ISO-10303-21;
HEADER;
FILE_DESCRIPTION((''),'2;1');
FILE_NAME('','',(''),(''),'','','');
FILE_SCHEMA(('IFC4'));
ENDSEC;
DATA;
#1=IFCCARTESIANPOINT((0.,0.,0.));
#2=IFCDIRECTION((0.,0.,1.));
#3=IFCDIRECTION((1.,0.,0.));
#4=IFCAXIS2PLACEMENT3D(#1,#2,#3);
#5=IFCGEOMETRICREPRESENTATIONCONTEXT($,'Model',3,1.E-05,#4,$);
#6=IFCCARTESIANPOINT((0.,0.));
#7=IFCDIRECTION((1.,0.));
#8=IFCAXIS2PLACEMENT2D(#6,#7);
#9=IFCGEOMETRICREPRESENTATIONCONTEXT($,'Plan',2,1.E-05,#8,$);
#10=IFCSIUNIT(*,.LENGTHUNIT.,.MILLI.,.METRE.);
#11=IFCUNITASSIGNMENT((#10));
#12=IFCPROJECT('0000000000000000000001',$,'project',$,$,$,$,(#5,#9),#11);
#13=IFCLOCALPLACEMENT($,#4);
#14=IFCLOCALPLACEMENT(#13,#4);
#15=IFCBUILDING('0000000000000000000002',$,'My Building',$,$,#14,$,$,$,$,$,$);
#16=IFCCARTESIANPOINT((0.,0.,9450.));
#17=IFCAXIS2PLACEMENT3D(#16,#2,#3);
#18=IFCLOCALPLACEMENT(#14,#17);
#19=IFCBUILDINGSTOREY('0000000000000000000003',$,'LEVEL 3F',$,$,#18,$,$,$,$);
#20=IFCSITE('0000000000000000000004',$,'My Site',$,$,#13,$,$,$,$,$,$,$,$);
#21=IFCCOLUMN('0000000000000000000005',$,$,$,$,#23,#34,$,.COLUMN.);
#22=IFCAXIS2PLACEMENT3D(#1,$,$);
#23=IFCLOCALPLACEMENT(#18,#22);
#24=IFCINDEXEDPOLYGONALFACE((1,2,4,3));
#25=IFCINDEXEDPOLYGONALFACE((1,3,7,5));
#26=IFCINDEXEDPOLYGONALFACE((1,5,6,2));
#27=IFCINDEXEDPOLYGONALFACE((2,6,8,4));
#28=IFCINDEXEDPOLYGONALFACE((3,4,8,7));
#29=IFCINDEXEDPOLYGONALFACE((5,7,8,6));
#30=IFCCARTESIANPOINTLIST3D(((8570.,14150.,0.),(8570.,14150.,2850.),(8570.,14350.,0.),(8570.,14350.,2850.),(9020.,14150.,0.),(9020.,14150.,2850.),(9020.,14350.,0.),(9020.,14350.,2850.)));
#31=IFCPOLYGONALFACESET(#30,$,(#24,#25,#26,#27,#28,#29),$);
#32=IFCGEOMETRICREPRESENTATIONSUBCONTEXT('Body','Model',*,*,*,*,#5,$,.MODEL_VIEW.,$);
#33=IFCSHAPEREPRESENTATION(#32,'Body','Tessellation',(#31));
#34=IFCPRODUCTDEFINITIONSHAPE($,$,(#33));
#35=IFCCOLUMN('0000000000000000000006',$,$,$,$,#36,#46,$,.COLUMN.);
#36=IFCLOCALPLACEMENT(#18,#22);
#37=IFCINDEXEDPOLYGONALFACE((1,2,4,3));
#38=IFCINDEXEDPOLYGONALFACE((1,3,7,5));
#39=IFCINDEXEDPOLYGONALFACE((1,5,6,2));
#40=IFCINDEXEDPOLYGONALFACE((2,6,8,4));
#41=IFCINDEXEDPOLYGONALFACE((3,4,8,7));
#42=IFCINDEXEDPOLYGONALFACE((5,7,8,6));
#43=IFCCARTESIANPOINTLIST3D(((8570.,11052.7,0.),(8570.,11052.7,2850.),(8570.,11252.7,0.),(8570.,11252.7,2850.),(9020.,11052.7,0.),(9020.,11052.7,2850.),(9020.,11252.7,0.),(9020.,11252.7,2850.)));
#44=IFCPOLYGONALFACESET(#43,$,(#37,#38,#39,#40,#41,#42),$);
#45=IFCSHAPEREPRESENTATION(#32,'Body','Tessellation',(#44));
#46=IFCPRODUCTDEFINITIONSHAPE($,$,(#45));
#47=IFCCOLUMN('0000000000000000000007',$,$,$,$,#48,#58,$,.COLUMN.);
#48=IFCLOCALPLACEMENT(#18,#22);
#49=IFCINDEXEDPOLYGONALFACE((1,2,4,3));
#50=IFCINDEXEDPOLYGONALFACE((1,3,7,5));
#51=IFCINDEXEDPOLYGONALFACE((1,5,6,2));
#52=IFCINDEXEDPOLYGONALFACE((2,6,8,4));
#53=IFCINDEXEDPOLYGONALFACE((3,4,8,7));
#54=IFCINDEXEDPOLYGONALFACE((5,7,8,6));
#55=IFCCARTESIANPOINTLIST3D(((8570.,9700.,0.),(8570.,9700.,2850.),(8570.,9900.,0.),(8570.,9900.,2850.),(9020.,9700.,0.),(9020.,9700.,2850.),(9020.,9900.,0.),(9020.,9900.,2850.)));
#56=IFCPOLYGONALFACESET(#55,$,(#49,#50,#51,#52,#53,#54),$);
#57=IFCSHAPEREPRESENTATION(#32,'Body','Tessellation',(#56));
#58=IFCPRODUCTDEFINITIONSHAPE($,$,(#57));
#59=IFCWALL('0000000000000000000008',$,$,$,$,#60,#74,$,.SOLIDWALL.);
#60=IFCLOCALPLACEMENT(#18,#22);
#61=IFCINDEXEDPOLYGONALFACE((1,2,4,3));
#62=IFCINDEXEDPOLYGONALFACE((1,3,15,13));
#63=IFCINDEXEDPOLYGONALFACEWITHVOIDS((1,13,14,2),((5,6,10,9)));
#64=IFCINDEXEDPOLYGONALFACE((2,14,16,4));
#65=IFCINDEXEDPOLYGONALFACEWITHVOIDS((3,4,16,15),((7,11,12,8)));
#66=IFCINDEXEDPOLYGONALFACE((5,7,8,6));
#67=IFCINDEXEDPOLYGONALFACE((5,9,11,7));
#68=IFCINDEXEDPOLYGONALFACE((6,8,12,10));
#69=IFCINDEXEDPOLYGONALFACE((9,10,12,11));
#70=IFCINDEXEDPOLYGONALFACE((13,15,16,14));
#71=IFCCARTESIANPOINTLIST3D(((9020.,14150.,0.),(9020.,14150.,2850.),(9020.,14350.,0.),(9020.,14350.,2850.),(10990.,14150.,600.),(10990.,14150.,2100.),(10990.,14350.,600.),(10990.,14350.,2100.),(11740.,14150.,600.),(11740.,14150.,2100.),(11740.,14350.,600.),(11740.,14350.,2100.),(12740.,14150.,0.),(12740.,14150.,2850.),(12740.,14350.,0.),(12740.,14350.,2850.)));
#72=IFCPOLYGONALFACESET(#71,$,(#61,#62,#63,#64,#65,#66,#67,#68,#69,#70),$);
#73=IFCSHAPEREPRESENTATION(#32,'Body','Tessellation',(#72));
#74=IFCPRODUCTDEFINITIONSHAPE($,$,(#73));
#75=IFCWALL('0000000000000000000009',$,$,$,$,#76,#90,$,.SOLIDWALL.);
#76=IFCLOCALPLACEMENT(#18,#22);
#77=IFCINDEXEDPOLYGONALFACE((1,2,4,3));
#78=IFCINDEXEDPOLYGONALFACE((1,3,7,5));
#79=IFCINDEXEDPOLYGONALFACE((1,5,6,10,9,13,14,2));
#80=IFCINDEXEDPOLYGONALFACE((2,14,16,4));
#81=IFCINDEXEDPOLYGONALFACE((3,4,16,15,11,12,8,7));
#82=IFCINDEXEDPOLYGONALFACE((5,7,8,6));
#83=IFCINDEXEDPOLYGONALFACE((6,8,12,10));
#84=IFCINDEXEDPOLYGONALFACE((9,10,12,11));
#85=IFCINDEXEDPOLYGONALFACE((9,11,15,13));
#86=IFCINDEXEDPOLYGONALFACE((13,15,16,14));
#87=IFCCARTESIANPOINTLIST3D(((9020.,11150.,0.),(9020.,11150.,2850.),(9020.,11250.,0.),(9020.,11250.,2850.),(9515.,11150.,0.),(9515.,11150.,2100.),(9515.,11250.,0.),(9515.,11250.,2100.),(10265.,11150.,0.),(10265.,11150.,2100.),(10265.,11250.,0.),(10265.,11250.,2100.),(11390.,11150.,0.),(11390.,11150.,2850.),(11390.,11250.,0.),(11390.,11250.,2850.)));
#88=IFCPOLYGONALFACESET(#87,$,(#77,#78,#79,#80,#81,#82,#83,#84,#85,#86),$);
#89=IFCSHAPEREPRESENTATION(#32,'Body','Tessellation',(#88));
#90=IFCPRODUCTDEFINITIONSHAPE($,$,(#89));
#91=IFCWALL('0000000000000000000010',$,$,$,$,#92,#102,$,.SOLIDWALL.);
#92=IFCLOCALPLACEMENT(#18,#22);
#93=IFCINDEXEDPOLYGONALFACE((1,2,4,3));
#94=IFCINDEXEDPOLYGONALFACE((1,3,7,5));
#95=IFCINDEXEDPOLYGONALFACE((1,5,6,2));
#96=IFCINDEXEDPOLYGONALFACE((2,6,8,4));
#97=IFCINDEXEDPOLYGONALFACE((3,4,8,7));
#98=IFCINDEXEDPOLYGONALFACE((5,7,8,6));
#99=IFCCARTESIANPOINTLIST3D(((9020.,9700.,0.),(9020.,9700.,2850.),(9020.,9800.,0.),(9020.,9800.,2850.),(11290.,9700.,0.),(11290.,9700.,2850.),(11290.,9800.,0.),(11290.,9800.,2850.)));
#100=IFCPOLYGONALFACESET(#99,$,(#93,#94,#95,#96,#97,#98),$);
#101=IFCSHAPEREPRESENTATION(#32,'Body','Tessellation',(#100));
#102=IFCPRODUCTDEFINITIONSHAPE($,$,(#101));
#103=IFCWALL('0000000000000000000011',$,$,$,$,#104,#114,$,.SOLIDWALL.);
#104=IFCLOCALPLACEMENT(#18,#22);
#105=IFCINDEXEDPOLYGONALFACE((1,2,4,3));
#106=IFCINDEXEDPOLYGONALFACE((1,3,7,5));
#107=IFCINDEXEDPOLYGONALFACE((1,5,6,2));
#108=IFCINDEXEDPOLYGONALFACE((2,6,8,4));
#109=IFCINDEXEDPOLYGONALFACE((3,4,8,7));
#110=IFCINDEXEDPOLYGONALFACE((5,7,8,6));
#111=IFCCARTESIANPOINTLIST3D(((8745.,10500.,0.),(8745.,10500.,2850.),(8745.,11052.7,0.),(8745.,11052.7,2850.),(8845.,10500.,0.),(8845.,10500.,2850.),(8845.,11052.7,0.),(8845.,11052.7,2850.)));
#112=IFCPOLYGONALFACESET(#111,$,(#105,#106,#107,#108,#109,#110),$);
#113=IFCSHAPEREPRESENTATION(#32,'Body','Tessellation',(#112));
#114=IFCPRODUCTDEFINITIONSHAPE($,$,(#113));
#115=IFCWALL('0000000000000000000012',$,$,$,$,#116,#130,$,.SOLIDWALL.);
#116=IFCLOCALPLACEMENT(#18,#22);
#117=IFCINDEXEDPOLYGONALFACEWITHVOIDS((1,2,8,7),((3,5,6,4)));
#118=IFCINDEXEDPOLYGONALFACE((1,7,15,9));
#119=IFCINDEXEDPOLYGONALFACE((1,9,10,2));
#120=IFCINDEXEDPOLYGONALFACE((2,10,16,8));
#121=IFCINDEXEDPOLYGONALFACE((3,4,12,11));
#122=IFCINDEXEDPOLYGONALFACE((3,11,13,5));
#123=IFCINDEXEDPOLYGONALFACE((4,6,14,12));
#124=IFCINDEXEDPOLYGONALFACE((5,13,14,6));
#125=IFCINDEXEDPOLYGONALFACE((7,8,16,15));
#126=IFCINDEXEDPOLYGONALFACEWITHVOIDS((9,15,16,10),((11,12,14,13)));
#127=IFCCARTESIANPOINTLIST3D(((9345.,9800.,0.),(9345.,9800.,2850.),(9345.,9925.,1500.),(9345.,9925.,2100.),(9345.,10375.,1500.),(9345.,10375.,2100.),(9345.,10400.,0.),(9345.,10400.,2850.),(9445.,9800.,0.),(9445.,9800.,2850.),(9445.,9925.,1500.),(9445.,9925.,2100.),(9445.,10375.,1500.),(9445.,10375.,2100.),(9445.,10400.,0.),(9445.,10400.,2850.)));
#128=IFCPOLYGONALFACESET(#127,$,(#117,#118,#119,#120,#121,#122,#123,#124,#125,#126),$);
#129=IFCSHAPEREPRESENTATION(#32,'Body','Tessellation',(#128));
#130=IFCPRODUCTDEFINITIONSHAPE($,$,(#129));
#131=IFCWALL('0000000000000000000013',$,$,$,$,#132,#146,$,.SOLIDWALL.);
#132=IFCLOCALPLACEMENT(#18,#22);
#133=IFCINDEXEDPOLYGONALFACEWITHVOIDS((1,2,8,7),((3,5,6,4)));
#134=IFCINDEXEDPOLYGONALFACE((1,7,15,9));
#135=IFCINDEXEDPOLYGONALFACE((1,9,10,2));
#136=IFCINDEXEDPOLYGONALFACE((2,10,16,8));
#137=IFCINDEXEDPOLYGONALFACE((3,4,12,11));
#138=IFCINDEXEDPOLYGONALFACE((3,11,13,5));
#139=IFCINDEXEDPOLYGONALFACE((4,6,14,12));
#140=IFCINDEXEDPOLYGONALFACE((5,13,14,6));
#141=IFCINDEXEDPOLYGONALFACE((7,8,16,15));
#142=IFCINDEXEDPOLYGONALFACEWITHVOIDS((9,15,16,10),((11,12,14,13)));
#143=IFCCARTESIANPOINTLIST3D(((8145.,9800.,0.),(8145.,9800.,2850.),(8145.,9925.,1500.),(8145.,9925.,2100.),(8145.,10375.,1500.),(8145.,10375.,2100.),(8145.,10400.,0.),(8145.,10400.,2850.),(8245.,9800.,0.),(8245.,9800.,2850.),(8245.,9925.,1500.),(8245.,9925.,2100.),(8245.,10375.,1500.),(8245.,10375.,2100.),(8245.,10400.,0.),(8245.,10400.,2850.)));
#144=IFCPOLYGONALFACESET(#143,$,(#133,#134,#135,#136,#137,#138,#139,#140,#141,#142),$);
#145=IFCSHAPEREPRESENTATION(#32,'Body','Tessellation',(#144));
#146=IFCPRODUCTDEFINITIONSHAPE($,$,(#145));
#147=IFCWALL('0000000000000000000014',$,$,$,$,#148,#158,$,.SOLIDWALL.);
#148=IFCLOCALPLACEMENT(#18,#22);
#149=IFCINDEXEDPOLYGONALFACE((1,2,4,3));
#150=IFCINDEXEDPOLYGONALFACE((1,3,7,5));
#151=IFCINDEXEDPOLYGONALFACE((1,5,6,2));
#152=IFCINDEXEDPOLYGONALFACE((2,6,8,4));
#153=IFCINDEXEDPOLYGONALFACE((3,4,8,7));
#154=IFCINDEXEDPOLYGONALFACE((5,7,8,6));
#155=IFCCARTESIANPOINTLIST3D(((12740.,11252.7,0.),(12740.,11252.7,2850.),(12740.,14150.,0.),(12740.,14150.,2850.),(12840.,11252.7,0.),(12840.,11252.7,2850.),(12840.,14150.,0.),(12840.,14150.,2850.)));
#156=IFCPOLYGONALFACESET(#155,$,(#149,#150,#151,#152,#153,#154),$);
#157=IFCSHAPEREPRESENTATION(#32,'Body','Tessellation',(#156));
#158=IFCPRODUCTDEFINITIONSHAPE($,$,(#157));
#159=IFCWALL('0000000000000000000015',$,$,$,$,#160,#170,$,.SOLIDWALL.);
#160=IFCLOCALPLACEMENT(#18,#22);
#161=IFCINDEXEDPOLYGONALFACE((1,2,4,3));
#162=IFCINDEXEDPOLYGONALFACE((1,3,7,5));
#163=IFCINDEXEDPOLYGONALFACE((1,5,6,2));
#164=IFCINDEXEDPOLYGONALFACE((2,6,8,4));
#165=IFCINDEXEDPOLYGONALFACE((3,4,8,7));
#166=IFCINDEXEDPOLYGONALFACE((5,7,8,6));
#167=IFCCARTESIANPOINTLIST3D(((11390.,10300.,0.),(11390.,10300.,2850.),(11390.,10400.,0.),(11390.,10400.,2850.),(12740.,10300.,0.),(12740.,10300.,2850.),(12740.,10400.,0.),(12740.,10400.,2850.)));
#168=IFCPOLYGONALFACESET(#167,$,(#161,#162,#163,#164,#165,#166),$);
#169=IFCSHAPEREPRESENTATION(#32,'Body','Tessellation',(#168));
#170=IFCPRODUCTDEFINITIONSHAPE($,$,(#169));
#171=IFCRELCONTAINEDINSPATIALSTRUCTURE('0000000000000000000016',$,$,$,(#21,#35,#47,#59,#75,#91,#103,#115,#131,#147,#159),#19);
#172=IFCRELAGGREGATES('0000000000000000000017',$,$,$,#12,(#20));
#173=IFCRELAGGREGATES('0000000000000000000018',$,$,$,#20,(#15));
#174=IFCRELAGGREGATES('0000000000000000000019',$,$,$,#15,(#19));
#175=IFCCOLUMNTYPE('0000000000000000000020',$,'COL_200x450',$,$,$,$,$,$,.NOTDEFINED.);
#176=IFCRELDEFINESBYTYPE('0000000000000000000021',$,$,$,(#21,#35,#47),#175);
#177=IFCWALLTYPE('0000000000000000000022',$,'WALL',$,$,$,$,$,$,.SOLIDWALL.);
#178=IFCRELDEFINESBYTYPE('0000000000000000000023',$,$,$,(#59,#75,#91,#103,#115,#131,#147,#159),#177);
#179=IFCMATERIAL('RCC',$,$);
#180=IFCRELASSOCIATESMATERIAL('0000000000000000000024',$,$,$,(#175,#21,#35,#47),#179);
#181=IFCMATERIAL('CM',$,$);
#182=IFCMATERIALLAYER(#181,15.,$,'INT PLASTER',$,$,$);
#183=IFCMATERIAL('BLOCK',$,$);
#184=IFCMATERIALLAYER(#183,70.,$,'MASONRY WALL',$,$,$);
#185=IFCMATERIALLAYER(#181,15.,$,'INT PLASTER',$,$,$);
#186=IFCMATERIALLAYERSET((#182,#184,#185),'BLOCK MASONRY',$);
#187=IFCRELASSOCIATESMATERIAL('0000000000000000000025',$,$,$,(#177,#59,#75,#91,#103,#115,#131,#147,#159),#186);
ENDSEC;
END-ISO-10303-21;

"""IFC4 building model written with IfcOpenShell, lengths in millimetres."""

from ifc_helpers import new_model, si_unit, frame, origin_with_axes, origin_2d_with_axis, place, context, subcontext, project, spatial, indexed_curve, rectangle, outline, extrude, material, layer, layer_set, layer_usage, material_profile, profile_set, profile_usage, type_object, element, save


model = new_model("IFC4")

# Units and contexts
model_context = context("Model", 3, precision=1e-05, world=origin_with_axes())
plan_context = context("Plan", 2, precision=1e-05, world=origin_2d_with_axis())
body_context = subcontext(model_context, "Body", "Model", "MODEL_VIEW")
ifc_project = project(units=[si_unit("LENGTHUNIT", "METRE", prefix="MILLI")], contexts=[model_context, plan_context])

# Site, building, storey
site_placement = place(None, origin_with_axes())
site = spatial("IfcSite", under=ifc_project, at=site_placement, Name="My Site")
building_placement = place(site_placement, origin_with_axes())
building = spatial("IfcBuilding", under=site, at=building_placement, Name="My Building")
storey_placement = place(building_placement, frame((0.0, 0.0, 9450.0), z_axis=(0.0, 0.0, 1.0), x_axis=(1.0, 0.0, 0.0)))
storey = spatial("IfcBuildingStorey", under=building, at=storey_placement, Name="LEVEL 3F")

# Columns
ifc_material_1 = material(Name="RCC")
ifc_material_profile = material_profile(ifc_material_1, rectangle(XDim=200.0, YDim=450.0))
ifc_profile_set = profile_set([ifc_material_profile], Name="COL_200x450")
ifc_profile_usage_1 = profile_usage(ifc_profile_set)
column_type = type_object("IfcColumnType", Name="COL_200x450", PredefinedType="NOTDEFINED", material=ifc_profile_set)
column_1_placement = place(storey_placement, frame((8795.0, 14250.0, 0.0), z_axis=(0.0, 0.0, 1.0), x_axis=(0.0, -1.0, 0.0)))
element("IfcColumn", 1, at=column_1_placement, inside=storey, type_object=column_type, material=ifc_profile_usage_1, PredefinedType="COLUMN", context=body_context, shape_type="SweptSolid", body=[
    extrude(rectangle(XDim=200.0, YDim=450.0), origin_with_axes(), (0.0, 0.0, 1.0), 2850.0),
])
ifc_profile_usage_2 = profile_usage(ifc_profile_set)
column_2_placement = place(storey_placement, frame((8795.0, 11152.7, 0.0), z_axis=(0.0, 0.0, 1.0), x_axis=(0.0, -1.0, 0.0)))
element("IfcColumn", 2, at=column_2_placement, inside=storey, type_object=column_type, material=ifc_profile_usage_2, PredefinedType="COLUMN", context=body_context, shape_type="SweptSolid", body=[
    extrude(rectangle(XDim=200.0, YDim=450.0), origin_with_axes(), (0.0, 0.0, 1.0), 2850.0),
])
ifc_profile_usage_3 = profile_usage(ifc_profile_set)
column_3_placement = place(storey_placement, frame((8795.0, 9800.0, 0.0), z_axis=(0.0, 0.0, 1.0), x_axis=(0.0, -1.0, 0.0)))
element("IfcColumn", 3, at=column_3_placement, inside=storey, type_object=column_type, material=ifc_profile_usage_3, PredefinedType="COLUMN", context=body_context, shape_type="SweptSolid", body=[
    extrude(rectangle(XDim=200.0, YDim=450.0), origin_with_axes(), (0.0, 0.0, 1.0), 2850.0),
])

# Walls, openings
ifc_material_2 = material(Name="CM")
ifc_layer_1 = layer(ifc_material_2, 15.0, Name="INT PLASTER")
ifc_material_3 = material(Name="BLOCK")
ifc_layer_2 = layer(ifc_material_3, 70.0, Name="MASONRY WALL")
ifc_layer_3 = layer(ifc_material_2, 15.0, Name="INT PLASTER")
ifc_layer_set = layer_set([ifc_layer_1, ifc_layer_2, ifc_layer_3], Name="BLOCK MASONRY")
ifc_layer_usage_1 = layer_usage(ifc_layer_set, "AXIS2", "POSITIVE", 0.0)
wall_type = type_object("IfcWallType", Name="WALL", PredefinedType="SOLIDWALL", material=ifc_layer_set)
wall_1_placement = place(storey_placement, frame((9020.0, 14350.0, 0.0), z_axis=(0.0, 0.0, 1.0), x_axis=(0.0, -1.0, 0.0)))
wall_1 = element("IfcWall", 4, at=wall_1_placement, inside=storey, type_object=wall_type, material=ifc_layer_usage_1, PredefinedType="SOLIDWALL", context=body_context, shape_type="SweptSolid", body=[
    extrude(outline(indexed_curve([(0.0, 0.0), (0.0, 3720.0), (200.0, 3720.0), (200.0, 0.0), (0.0, 0.0)], self_intersect=False)), origin_with_axes(), (0.0, 0.0, 1.0), 2850.0),
])
opening_1_placement = place(wall_1_placement, frame((200.0, 1970.0, 600.0), z_axis=(0.0, 0.0, 1.0), x_axis=(0.0, 1.0, 0.0)))
element("IfcOpeningElement", 5, at=opening_1_placement, cuts=wall_1, PredefinedType="OPENING", context=body_context, shape_type="SweptSolid", body=[
    extrude(outline(indexed_curve([(0.0, 0.0), (0.0, 400.0), (750.0, 400.0), (750.0, 0.0), (0.0, 0.0)], self_intersect=False)), frame((0.0, -100.0, 0.0), z_axis=(0.0, 0.0, 1.0), x_axis=(1.0, 0.0, 0.0)), (0.0, 0.0, 1.0), 1500.0),
])
ifc_layer_usage_2 = layer_usage(ifc_layer_set, "AXIS2", "POSITIVE", 0.0)
wall_2_placement = place(storey_placement, frame((9020.0, 11250.0, 0.0), z_axis=(0.0, 0.0, 1.0), x_axis=(0.0, -1.0, 0.0)))
wall_2 = element("IfcWall", 6, at=wall_2_placement, inside=storey, type_object=wall_type, material=ifc_layer_usage_2, PredefinedType="SOLIDWALL", context=body_context, shape_type="SweptSolid", body=[
    extrude(outline(indexed_curve([(0.0, 0.0), (0.0, 2370.0), (100.0, 2370.0), (100.0, 0.0), (0.0, 0.0)], self_intersect=False)), origin_with_axes(), (0.0, 0.0, 1.0), 2850.0),
])
opening_2_placement = place(wall_2_placement, frame((0.0, 1245.0, 0.0), z_axis=(0.0, 0.0, 1.0), x_axis=(0.0, -1.0, 0.0)))
element("IfcOpeningElement", 7, at=opening_2_placement, cuts=wall_2, PredefinedType="OPENING", context=body_context, shape_type="SweptSolid", body=[
    extrude(outline(indexed_curve([(0.0, 0.0), (0.0, 400.0), (750.0, 400.0), (750.0, 0.0), (0.0, 0.0)], self_intersect=False)), frame((0.0, -100.0, 0.0), z_axis=(0.0, 0.0, 1.0), x_axis=(1.0, 0.0, 0.0)), (0.0, 0.0, 1.0), 2100.0),
])

# Wall
ifc_layer_usage_3 = layer_usage(ifc_layer_set, "AXIS2", "POSITIVE", 0.0)
wall_3_placement = place(storey_placement, frame((9020.0, 9800.0, 0.0), z_axis=(0.0, 0.0, 1.0), x_axis=(0.0, -1.0, 0.0)))
element("IfcWall", 8, at=wall_3_placement, inside=storey, type_object=wall_type, material=ifc_layer_usage_3, PredefinedType="SOLIDWALL", context=body_context, shape_type="SweptSolid", body=[
    extrude(outline(indexed_curve([(0.0, 0.0), (0.0, 2270.0), (100.0, 2270.0), (100.0, 0.0), (0.0, 0.0)], self_intersect=False)), origin_with_axes(), (0.0, 0.0, 1.0), 2850.0),
])

# Wall
ifc_layer_usage_4 = layer_usage(ifc_layer_set, "AXIS2", "POSITIVE", 0.0)
wall_4_placement = place(storey_placement, frame((8845.0, 10500.0, 0.0), z_axis=(0.0, 0.0, 1.0), x_axis=(0.0, 1.0, 0.0)))
element("IfcWall", 9, at=wall_4_placement, inside=storey, type_object=wall_type, material=ifc_layer_usage_4, PredefinedType="SOLIDWALL", context=body_context, shape_type="SweptSolid", body=[
    extrude(outline(indexed_curve([(0.0, 0.0), (0.0, 100.0), (552.7, 100.0), (552.7, 0.0), (0.0, 0.0)], self_intersect=False)), origin_with_axes(), (0.0, 0.0, 1.0), 2850.0),
])

# Walls, openings
ifc_layer_usage_5 = layer_usage(ifc_layer_set, "AXIS2", "POSITIVE", 0.0)
wall_5_placement = place(storey_placement, frame((9445.0, 9800.0, 0.0), z_axis=(0.0, 0.0, 1.0), x_axis=(0.0, 1.0, 0.0)))
wall_5 = element("IfcWall", 10, at=wall_5_placement, inside=storey, type_object=wall_type, material=ifc_layer_usage_5, PredefinedType="SOLIDWALL", context=body_context, shape_type="SweptSolid", body=[
    extrude(outline(indexed_curve([(0.0, 0.0), (0.0, 100.0), (600.0, 100.0), (600.0, 0.0), (0.0, 0.0)], self_intersect=False)), origin_with_axes(), (0.0, 0.0, 1.0), 2850.0),
])
opening_3_placement = place(wall_5_placement, frame((125.0, 0.0, 1500.0), z_axis=(0.0, 0.0, 1.0), x_axis=(1.0, 0.0, 0.0)))
element("IfcOpeningElement", 11, at=opening_3_placement, cuts=wall_5, PredefinedType="OPENING", context=body_context, shape_type="SweptSolid", body=[
    extrude(outline(indexed_curve([(0.0, 0.0), (0.0, 400.0), (450.0, 400.0), (450.0, 0.0), (0.0, 0.0)], self_intersect=False)), frame((0.0, -100.0, 0.0), z_axis=(0.0, 0.0, 1.0), x_axis=(1.0, 0.0, 0.0)), (0.0, 0.0, 1.0), 600.0),
])
ifc_layer_usage_6 = layer_usage(ifc_layer_set, "AXIS2", "POSITIVE", 0.0)
wall_6_placement = place(storey_placement, frame((8245.0, 9800.0, 0.0), z_axis=(0.0, 0.0, 1.0), x_axis=(0.0, 1.0, 0.0)))
wall_6 = element("IfcWall", 12, at=wall_6_placement, inside=storey, type_object=wall_type, material=ifc_layer_usage_6, PredefinedType="SOLIDWALL", context=body_context, shape_type="SweptSolid", body=[
    extrude(outline(indexed_curve([(0.0, 0.0), (0.0, 100.0), (600.0, 100.0), (600.0, 0.0), (0.0, 0.0)], self_intersect=False)), origin_with_axes(), (0.0, 0.0, 1.0), 2850.0),
])
opening_4_placement = place(wall_6_placement, frame((575.0, 100.0, 1500.0), z_axis=(0.0, 0.0, 1.0), x_axis=(-1.0, 0.0, 0.0)))
element("IfcOpeningElement", 13, at=opening_4_placement, cuts=wall_6, PredefinedType="OPENING", context=body_context, shape_type="SweptSolid", body=[
    extrude(outline(indexed_curve([(0.0, 0.0), (0.0, 400.0), (450.0, 400.0), (450.0, 0.0), (0.0, 0.0)], self_intersect=False)), frame((0.0, -100.0, 0.0), z_axis=(0.0, 0.0, 1.0), x_axis=(1.0, 0.0, 0.0)), (0.0, 0.0, 1.0), 600.0),
])

# Walls
ifc_layer_usage_7 = layer_usage(ifc_layer_set, "AXIS2", "POSITIVE", 0.0)
wall_7_placement = place(storey_placement, frame((12840.0, 11252.7, 0.0), z_axis=(0.0, 0.0, 1.0), x_axis=(0.0, 1.0, 0.0)))
element("IfcWall", 14, at=wall_7_placement, inside=storey, type_object=wall_type, material=ifc_layer_usage_7, PredefinedType="SOLIDWALL", context=body_context, shape_type="SweptSolid", body=[
    extrude(outline(indexed_curve([(0.0, 0.0), (0.0, 100.0), (2897.3, 100.0), (2897.3, 0.0), (0.0, 0.0)], self_intersect=False)), origin_with_axes(), (0.0, 0.0, 1.0), 2850.0),
])
ifc_layer_usage_8 = layer_usage(ifc_layer_set, "AXIS2", "POSITIVE", 0.0)
wall_8_placement = place(storey_placement, frame((11390.0, 10400.0, 0.0), z_axis=(0.0, 0.0, 1.0), x_axis=(0.0, -1.0, 0.0)))
element("IfcWall", 15, at=wall_8_placement, inside=storey, type_object=wall_type, material=ifc_layer_usage_8, PredefinedType="SOLIDWALL", context=body_context, shape_type="SweptSolid", body=[
    extrude(outline(indexed_curve([(0.0, 0.0), (0.0, 1350.0), (100.0, 1350.0), (100.0, 0.0), (0.0, 0.0)], self_intersect=False)), origin_with_axes(), (0.0, 0.0, 1.0), 2850.0),
])

save(model, "model.ifc")
